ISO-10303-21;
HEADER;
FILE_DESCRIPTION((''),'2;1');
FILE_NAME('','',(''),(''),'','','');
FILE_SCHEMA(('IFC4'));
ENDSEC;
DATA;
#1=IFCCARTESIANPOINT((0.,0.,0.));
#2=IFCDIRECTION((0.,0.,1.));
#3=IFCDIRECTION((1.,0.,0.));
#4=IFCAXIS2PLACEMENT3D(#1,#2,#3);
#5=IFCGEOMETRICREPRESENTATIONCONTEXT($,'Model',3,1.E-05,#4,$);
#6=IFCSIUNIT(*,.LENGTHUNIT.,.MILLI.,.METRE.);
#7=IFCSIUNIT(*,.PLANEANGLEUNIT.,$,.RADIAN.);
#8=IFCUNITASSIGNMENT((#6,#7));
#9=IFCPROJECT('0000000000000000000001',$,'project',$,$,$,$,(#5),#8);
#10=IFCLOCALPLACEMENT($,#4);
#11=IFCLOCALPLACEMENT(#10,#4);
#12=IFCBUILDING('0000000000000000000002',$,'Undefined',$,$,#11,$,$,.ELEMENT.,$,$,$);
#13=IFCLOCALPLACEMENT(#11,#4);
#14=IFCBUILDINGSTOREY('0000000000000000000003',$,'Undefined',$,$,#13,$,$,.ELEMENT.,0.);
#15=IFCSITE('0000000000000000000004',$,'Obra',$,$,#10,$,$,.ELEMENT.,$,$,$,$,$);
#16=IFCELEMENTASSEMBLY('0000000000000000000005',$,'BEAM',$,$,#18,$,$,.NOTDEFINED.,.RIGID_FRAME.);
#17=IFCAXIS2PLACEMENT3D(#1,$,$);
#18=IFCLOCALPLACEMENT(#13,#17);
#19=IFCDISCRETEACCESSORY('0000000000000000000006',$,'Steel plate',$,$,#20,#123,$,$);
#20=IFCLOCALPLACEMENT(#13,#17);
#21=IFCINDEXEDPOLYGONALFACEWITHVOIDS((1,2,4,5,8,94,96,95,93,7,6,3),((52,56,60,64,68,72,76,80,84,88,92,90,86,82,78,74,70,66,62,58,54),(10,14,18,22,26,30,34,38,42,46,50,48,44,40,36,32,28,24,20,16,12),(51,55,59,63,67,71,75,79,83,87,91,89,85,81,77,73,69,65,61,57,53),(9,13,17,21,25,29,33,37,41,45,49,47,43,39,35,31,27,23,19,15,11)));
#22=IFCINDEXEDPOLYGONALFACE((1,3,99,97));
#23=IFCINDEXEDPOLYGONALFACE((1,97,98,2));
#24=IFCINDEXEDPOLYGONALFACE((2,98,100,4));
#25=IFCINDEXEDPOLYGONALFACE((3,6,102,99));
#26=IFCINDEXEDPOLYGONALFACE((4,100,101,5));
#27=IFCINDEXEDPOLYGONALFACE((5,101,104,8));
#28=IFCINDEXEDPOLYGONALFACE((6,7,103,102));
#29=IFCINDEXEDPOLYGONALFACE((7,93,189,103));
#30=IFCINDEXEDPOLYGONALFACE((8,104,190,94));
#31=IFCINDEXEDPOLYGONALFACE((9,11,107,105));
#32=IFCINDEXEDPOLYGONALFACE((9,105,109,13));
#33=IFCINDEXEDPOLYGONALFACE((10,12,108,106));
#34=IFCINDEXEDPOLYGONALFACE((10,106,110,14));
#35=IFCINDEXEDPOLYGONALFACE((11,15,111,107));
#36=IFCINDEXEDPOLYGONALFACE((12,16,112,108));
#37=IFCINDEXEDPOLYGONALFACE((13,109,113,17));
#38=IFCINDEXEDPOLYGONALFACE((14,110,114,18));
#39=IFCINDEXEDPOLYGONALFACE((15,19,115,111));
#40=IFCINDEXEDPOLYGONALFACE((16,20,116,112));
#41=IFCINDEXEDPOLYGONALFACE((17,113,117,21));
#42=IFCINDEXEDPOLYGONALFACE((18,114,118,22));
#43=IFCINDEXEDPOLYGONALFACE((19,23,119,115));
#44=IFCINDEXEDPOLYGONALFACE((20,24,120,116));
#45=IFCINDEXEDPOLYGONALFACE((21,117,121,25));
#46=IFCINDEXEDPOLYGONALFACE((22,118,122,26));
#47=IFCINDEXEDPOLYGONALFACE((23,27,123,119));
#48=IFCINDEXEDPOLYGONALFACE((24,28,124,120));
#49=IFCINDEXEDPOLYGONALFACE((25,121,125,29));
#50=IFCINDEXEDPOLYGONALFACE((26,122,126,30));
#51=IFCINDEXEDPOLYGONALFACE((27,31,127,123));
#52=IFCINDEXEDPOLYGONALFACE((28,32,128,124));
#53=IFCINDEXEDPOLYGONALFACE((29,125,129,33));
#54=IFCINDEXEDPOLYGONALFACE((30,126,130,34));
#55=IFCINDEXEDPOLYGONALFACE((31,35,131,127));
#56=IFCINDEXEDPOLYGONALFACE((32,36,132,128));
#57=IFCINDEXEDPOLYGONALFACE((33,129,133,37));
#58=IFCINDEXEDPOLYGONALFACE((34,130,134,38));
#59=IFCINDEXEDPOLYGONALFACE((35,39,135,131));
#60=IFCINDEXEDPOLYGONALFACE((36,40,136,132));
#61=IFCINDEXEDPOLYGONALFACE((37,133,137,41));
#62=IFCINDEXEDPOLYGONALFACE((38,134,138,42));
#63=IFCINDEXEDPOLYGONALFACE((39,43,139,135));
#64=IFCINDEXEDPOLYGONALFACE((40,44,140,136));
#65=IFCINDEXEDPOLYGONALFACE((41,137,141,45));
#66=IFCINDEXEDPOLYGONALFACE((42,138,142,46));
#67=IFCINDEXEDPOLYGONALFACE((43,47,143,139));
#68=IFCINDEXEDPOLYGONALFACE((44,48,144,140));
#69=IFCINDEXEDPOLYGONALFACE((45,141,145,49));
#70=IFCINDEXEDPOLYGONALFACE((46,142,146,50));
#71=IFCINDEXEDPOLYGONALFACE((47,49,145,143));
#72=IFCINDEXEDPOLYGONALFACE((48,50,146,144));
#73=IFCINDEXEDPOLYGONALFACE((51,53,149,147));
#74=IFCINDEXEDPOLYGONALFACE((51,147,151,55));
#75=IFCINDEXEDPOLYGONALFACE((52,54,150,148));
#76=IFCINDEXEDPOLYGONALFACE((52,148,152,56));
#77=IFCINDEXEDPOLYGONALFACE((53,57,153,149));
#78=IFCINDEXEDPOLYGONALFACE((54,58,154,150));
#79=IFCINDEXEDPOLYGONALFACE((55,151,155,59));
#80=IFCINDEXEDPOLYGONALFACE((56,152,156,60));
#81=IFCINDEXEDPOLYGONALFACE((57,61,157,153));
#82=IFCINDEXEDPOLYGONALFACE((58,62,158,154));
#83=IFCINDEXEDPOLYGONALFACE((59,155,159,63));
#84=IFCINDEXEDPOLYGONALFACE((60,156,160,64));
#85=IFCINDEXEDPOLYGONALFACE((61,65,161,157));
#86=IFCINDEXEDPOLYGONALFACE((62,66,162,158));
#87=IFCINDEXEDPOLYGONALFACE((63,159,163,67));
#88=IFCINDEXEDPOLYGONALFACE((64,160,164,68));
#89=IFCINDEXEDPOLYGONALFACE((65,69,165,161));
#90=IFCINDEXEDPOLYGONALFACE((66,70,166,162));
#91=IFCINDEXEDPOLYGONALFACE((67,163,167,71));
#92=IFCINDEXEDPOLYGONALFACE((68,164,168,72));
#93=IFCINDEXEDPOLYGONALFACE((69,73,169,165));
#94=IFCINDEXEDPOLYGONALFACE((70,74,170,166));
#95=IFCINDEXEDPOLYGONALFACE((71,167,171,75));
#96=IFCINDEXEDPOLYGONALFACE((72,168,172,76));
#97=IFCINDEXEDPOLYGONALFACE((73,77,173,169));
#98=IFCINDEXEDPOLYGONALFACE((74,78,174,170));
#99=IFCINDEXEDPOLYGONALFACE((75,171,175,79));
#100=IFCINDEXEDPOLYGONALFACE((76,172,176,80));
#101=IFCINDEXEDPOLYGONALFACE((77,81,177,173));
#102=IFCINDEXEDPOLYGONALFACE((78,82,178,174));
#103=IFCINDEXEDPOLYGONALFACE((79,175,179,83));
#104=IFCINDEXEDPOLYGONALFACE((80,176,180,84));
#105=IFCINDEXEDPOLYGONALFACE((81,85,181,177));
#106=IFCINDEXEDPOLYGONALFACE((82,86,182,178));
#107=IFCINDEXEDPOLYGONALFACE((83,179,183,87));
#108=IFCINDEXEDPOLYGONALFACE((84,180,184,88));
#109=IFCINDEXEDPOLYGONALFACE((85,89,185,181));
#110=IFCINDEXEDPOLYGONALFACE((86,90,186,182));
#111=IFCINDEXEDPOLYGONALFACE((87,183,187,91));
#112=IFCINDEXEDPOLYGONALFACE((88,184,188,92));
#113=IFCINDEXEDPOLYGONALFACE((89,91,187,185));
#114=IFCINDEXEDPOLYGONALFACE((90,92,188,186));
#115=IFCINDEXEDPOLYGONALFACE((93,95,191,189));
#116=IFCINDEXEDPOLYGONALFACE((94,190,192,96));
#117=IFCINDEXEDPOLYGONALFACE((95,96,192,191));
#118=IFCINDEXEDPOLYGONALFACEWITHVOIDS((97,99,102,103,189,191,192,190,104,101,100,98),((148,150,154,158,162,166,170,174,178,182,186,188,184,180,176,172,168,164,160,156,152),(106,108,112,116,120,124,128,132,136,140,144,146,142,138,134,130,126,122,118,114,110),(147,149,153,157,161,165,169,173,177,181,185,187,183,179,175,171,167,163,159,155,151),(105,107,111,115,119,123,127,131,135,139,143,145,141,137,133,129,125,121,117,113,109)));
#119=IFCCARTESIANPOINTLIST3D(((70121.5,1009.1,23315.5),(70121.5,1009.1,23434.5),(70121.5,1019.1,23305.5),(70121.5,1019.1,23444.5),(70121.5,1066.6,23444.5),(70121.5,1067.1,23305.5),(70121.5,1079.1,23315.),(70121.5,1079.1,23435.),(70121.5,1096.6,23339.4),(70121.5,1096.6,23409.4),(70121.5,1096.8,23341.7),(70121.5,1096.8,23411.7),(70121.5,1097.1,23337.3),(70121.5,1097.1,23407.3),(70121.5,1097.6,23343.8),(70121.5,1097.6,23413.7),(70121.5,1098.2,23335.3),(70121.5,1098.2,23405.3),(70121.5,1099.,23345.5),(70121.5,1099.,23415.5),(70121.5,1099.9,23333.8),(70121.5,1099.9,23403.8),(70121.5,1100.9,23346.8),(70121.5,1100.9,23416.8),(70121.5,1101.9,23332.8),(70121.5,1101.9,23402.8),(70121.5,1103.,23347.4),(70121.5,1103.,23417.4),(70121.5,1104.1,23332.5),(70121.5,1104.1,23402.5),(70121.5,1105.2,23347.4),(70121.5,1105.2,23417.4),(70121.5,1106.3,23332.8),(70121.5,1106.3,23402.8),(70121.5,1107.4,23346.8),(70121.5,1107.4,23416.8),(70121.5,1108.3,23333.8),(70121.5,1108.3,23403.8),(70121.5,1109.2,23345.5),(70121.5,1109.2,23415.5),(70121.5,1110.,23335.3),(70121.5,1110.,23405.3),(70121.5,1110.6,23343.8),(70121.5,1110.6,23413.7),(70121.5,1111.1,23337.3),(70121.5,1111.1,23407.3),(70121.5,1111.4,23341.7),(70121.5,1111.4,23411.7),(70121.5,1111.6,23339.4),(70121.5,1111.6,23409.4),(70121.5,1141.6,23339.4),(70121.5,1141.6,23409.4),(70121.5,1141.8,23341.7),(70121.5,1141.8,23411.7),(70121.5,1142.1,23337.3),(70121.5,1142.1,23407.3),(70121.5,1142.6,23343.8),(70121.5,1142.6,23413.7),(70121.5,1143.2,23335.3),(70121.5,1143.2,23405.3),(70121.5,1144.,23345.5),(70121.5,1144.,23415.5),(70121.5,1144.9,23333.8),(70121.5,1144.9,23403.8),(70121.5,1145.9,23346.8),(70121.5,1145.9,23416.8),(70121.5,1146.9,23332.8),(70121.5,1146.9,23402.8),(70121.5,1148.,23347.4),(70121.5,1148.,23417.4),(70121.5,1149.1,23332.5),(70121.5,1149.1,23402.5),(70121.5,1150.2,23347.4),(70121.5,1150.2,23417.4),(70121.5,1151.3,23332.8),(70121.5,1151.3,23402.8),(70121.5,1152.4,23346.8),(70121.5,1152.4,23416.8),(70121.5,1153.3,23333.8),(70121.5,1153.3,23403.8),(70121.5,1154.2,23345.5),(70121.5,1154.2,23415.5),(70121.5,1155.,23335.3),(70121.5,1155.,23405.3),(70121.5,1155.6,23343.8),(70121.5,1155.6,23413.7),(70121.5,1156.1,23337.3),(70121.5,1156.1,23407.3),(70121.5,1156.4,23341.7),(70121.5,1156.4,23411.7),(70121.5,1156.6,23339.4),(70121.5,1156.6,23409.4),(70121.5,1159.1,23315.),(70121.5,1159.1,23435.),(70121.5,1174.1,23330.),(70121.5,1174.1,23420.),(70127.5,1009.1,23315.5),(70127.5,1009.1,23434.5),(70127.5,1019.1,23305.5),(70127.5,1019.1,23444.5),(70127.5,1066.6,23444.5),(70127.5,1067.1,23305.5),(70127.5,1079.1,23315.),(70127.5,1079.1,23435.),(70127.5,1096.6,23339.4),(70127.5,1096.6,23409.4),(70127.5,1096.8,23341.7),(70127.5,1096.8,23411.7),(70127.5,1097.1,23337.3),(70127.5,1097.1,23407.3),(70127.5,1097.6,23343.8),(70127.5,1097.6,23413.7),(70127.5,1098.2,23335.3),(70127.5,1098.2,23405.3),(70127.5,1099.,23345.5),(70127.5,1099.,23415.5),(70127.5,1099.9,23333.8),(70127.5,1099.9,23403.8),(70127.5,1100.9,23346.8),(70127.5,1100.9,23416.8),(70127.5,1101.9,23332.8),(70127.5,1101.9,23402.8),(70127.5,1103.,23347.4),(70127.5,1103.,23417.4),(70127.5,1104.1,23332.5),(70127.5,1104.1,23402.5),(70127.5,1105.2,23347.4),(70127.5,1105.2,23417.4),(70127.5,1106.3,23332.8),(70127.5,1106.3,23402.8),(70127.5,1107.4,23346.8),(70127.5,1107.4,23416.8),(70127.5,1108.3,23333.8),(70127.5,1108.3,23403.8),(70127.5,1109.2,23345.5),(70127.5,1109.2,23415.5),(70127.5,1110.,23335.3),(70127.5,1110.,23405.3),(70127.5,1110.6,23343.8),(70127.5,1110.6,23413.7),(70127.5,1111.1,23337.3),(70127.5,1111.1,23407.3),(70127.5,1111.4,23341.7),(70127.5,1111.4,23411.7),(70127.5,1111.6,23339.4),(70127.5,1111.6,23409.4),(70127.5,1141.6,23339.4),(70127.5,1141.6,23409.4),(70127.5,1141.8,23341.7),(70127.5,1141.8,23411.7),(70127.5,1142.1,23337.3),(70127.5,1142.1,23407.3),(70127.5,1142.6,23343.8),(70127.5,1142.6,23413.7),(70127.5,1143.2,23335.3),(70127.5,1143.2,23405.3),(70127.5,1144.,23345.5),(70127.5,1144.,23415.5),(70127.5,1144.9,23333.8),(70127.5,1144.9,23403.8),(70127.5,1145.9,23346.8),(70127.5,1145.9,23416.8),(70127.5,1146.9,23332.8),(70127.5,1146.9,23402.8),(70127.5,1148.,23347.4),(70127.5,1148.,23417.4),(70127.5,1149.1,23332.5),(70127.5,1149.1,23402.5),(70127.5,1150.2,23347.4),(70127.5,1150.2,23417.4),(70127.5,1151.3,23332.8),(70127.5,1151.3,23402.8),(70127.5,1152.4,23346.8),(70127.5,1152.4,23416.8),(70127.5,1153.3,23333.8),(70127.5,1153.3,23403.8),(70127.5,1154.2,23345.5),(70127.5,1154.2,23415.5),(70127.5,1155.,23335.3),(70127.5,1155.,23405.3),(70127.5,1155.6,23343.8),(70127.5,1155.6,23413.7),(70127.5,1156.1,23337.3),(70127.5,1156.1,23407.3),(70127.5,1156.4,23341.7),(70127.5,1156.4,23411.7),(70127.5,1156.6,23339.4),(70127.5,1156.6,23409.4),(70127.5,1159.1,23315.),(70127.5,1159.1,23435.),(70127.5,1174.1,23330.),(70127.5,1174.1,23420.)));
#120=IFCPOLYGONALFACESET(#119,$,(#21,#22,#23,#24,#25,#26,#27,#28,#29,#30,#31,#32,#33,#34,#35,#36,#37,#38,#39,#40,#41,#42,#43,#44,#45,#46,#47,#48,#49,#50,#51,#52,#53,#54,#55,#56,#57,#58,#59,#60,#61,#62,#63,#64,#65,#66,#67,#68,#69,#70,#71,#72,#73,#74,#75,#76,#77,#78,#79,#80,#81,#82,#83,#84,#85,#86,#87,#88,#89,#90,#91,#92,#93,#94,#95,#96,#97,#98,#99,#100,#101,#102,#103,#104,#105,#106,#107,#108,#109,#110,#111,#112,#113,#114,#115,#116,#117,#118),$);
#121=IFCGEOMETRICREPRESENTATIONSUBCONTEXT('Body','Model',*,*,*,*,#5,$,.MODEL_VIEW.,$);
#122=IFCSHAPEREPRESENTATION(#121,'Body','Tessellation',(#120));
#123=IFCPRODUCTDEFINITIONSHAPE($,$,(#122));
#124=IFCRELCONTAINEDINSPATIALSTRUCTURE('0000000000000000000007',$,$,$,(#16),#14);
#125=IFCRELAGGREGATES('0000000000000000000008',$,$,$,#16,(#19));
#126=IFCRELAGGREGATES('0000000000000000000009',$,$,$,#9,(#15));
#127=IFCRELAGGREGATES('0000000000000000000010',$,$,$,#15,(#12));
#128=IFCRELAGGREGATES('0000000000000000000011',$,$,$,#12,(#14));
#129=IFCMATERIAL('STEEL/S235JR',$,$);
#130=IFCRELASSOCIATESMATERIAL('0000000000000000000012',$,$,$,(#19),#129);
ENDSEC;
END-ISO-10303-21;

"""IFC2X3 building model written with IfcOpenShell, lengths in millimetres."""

from ifc_helpers import new_model, si_unit, frame, origin_with_axes, origin_2d_with_axis, place, context, subcontext, project, spatial, polyline, circle, outline, extrude, source, transform, mapped, material, element, aggregate, save


model = new_model("IFC2X3")

# Units and contexts
model_context = context("Model", 3, precision=1e-05, world=origin_with_axes())
body_context = subcontext(model_context, "Body", "Model", "MODEL_VIEW")
ifc_project = project(units=[si_unit("LENGTHUNIT", "METRE", prefix="MILLI"), si_unit("PLANEANGLEUNIT", "RADIAN")], contexts=[model_context])

# Site, building, storey
site_placement = place(None, origin_with_axes())
site = spatial("IfcSite", under=ifc_project, at=site_placement, Name="Obra", CompositionType="ELEMENT")
building_placement = place(site_placement, origin_with_axes())
building = spatial("IfcBuilding", under=site, at=building_placement, Name="Undefined", CompositionType="ELEMENT")
storey_placement = place(building_placement, origin_with_axes())
storey = spatial("IfcBuildingStorey", under=building, at=storey_placement, Name="Undefined", CompositionType="ELEMENT", Elevation=0.0)

# Shared definitions
ifc_material_1 = material(Name="STEEL/S235JR")

# Element assembly
assembly_1_placement = place(storey_placement, origin_with_axes())
assembly_1 = element("IfcElementAssembly", 1, at=assembly_1_placement, inside=storey, Name="BEAM", AssemblyPlace="NOTDEFINED", PredefinedType="RIGID_FRAME")

# Discrete accessory, opening
shared_shape_1 = source(origin_with_axes(), body_context, "Body", "SweptSolid", [
    extrude(circle(Radius=7.5, at=origin_2d_with_axis()), frame((0.0, 2.4, 0.0), z_axis=(0.0, 1.0, 0.0), x_axis=(1.0, 0.0, 0.0)), (0.0, 0.0, 1.0), 6.2),
])
discrete_accessory_1_placement = place(assembly_1_placement, frame((70124.5, 1009.1, 23315.5), z_axis=(1.0, 0.0, 0.0), x_axis=(0.0, 0.707107, -0.707107)))
discrete_accessory_1 = element("IfcDiscreteAccessory", 2, at=discrete_accessory_1_placement, material=ifc_material_1, Name="Steel plate", context=body_context, shape_type="SweptSolid", body=[
    extrude(outline(polyline([(0.0, 0.0), (14.1, 0.0), (48.1, 33.9), (49.9, 49.1), (106.4, 105.7), (106.4, 126.9), (42.8, 190.6), (21.6, 190.6), (-35.0, 134.0), (-50.6, 131.9), (-84.1, 98.3), (-84.1, 84.1), (0.0, 0.0)])), frame((0.0, 0.0, -3.0), z_axis=(0.0, 0.0, 1.0), x_axis=(1.0, 0.0, 0.0)), (0.0, 0.0, 1.0), 6.0),
])
opening_1_placement = place(assembly_1_placement, frame((70130.0, 1126.6, 23410.0), z_axis=(0.0, 1.0, 0.0), x_axis=(0.0, 0.0, -1.0)))
element("IfcOpeningElement", 3, at=opening_1_placement, cuts=discrete_accessory_1, ObjectType="Opening", context=body_context, shape_type="MappedRepresentation", body=[
    mapped(shared_shape_1, transform((0.0, 0.0, -22.5))),
    mapped(shared_shape_1, transform((70.0, 0.0, -22.5))),
    mapped(shared_shape_1, transform((0.0, 0.0, 22.5))),
    mapped(shared_shape_1, transform((70.0, 0.0, 22.5))),
])
aggregate(assembly_1, [discrete_accessory_1])

save(model, "model.ifc")
